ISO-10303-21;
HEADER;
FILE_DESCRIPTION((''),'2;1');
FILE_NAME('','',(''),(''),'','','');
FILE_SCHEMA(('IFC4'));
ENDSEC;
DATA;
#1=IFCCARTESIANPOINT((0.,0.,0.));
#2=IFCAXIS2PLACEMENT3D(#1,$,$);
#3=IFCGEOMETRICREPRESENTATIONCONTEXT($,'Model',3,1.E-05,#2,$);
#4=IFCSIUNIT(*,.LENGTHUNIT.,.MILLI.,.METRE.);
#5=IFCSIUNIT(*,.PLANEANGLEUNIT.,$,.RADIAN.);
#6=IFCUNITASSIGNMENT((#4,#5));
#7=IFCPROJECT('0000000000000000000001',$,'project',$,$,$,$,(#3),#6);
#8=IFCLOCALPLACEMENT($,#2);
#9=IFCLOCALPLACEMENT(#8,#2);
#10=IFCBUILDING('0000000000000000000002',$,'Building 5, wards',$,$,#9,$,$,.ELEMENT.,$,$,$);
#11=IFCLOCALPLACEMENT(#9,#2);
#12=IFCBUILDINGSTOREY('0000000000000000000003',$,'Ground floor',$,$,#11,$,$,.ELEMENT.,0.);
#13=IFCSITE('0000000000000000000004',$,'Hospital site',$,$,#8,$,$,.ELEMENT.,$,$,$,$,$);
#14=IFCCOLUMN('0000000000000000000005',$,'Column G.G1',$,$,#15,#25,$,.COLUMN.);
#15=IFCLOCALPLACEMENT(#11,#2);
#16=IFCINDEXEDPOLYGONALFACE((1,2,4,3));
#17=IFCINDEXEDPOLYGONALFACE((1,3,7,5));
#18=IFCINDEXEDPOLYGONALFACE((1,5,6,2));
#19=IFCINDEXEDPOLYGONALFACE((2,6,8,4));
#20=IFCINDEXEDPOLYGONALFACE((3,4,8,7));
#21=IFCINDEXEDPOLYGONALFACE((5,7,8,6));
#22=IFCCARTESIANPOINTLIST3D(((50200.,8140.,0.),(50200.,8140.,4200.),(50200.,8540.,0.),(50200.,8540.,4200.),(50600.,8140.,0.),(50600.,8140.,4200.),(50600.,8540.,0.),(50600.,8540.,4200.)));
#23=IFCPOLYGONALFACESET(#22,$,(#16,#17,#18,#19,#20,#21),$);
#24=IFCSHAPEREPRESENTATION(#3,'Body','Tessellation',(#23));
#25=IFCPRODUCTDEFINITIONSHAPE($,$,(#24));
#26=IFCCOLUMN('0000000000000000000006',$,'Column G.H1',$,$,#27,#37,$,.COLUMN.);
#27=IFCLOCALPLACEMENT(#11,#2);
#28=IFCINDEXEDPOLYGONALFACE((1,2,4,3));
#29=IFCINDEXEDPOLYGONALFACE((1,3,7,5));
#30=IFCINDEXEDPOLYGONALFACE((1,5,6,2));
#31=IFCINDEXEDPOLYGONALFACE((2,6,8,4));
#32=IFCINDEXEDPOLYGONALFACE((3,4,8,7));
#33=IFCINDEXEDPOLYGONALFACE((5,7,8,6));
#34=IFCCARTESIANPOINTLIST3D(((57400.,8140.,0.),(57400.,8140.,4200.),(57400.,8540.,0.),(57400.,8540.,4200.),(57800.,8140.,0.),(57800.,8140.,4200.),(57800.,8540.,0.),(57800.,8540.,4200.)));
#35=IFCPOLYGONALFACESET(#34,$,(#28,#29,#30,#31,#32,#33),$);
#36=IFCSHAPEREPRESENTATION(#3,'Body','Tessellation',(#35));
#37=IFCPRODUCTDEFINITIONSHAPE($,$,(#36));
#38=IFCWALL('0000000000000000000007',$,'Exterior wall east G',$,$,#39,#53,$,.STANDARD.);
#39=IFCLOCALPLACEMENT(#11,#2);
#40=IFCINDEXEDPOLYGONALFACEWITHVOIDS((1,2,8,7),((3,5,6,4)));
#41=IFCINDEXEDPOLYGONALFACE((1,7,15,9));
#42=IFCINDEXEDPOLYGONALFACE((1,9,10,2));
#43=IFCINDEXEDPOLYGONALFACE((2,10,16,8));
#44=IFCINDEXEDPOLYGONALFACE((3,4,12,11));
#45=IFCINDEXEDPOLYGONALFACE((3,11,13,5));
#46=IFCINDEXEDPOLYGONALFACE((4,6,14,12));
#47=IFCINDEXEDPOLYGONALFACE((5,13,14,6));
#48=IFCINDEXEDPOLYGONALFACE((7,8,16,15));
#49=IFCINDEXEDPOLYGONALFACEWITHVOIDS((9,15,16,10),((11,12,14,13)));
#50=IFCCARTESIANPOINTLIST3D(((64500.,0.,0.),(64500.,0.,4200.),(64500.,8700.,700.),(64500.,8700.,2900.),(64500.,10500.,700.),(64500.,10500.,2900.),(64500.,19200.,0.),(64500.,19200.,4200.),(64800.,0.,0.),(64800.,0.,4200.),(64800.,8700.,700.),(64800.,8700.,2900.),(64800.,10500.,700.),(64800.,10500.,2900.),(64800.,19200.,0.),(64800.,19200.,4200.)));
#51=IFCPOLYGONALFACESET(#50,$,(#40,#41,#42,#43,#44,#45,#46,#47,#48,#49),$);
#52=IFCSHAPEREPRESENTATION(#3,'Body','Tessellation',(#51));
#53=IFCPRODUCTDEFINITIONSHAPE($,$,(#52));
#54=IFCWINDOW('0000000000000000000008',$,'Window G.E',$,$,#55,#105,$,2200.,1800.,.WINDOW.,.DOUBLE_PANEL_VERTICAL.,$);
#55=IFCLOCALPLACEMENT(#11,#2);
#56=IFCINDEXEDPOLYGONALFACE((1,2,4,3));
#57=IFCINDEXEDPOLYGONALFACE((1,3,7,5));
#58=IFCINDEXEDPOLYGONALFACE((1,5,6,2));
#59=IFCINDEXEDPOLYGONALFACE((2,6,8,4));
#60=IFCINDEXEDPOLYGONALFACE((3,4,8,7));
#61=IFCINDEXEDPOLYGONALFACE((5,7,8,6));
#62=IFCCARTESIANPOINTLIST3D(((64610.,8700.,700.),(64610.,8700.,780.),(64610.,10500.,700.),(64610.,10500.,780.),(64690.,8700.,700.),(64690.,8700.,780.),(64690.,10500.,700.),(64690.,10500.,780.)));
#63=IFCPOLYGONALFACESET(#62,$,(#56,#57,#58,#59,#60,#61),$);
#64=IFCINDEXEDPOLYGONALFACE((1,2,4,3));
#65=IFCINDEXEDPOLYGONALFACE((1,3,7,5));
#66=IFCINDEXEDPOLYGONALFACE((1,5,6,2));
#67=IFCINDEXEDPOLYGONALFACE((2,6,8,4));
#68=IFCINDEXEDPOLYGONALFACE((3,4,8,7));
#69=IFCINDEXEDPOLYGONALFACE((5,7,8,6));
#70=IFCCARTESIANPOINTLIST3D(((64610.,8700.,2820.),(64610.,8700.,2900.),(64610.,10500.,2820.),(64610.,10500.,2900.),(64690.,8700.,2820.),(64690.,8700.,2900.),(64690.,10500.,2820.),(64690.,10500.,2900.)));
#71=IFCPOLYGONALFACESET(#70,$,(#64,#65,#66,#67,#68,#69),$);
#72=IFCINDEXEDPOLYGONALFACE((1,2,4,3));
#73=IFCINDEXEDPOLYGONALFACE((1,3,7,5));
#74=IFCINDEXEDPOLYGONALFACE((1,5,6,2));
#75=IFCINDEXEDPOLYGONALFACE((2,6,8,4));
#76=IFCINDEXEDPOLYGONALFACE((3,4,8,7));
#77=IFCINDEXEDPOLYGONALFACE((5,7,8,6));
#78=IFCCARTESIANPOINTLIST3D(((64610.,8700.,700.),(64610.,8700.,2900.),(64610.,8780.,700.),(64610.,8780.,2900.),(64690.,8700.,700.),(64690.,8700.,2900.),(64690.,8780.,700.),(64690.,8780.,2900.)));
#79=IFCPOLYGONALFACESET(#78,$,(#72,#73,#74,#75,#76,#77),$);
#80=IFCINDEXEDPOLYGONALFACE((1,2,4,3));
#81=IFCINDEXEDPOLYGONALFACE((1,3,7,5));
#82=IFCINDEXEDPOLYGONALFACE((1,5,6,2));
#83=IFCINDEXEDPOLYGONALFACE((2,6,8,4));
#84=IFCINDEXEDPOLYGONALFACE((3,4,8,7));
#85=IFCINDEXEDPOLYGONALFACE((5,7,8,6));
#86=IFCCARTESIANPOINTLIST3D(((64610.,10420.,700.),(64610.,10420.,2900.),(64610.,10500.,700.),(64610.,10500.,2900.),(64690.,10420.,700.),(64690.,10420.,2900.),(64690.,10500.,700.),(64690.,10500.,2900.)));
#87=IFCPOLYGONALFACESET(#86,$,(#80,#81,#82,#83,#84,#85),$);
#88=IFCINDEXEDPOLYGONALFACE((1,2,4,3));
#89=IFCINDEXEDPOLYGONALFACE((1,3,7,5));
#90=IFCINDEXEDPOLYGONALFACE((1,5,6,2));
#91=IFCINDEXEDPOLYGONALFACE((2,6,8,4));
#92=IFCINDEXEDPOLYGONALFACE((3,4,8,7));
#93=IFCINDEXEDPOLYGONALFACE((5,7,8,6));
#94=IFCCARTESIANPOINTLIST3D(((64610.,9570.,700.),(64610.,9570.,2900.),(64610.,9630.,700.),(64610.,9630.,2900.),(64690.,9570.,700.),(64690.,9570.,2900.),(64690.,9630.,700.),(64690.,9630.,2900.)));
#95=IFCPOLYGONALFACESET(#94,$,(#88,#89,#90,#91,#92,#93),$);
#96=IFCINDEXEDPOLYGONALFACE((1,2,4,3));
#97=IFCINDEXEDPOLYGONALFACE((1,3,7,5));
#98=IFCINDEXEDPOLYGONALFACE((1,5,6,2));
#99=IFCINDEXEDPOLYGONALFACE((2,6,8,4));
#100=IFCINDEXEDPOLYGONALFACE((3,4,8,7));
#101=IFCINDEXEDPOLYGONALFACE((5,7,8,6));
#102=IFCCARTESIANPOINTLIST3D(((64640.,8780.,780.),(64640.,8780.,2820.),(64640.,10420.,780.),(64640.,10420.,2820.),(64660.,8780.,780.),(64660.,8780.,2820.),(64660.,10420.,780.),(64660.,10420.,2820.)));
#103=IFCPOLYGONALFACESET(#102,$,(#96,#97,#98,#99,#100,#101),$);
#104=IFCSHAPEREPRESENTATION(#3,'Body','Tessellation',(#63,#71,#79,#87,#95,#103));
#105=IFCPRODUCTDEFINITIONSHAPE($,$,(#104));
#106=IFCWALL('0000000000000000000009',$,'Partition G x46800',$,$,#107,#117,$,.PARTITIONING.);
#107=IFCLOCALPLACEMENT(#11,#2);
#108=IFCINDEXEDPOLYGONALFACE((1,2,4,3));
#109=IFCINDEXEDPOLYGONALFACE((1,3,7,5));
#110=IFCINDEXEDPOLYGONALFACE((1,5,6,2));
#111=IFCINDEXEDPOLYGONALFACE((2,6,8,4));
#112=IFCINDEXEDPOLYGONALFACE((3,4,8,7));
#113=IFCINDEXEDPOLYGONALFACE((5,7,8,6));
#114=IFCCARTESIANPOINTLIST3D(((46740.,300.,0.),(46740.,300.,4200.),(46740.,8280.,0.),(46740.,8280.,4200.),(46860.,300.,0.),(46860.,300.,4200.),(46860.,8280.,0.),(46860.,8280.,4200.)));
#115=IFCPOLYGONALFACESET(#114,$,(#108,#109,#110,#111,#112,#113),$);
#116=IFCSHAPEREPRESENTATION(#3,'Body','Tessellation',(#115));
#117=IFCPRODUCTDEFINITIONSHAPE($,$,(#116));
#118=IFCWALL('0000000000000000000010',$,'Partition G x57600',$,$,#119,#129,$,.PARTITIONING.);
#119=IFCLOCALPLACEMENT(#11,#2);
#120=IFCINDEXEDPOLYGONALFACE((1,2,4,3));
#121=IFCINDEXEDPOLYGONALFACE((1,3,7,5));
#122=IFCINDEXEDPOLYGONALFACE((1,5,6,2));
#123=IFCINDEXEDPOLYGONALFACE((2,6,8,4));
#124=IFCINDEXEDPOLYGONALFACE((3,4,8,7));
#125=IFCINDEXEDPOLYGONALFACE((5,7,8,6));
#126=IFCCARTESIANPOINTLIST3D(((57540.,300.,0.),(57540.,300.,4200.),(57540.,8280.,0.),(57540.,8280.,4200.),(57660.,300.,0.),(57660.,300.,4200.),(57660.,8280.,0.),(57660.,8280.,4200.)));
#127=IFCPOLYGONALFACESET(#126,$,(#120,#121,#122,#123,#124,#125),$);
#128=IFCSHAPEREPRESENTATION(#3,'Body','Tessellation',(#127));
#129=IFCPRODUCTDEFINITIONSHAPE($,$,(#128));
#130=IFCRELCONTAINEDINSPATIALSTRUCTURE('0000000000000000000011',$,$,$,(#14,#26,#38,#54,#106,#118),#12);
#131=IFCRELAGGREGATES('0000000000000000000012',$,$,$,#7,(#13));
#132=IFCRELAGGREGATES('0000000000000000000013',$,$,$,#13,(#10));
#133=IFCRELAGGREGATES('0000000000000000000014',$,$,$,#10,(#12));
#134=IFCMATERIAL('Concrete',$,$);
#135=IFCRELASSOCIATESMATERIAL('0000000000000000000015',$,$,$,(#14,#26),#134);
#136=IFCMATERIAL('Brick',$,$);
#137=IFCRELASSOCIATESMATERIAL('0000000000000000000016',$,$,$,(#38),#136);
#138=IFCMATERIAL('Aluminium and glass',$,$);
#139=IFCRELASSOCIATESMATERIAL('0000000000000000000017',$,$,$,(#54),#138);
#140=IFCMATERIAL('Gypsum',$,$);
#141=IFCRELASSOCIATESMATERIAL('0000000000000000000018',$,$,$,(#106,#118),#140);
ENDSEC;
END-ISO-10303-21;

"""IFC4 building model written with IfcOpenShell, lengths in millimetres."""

from ifc_helpers import new_model, si_unit, frame, frame_2d, origin, origin_2d, place, context, project, spatial, rectangle, extrude, material, element, fill, save


model = new_model("IFC4")

# Units and contexts
model_context = context("Model", 3, precision=1e-05, world=origin())
ifc_project = project(units=[si_unit("LENGTHUNIT", "METRE", prefix="MILLI"), si_unit("PLANEANGLEUNIT", "RADIAN")], contexts=[model_context])

# Site, building, storey
site_placement = place(None, origin())
site = spatial("IfcSite", under=ifc_project, at=site_placement, Name="Hospital site", CompositionType="ELEMENT")
building_placement = place(site_placement, origin())
building = spatial("IfcBuilding", under=site, at=building_placement, Name="Building 5, wards", CompositionType="ELEMENT")
storey_placement = place(building_placement, origin())
storey = spatial("IfcBuildingStorey", under=building, at=storey_placement, Name="Ground floor", CompositionType="ELEMENT", Elevation=0.0)

# Columns
ifc_material_1 = material(Name="Concrete")
for number, where, name in (
    (1, (50400.0, 8340.0, 0.0), "Column G.G1"),
    (2, (57600.0, 8340.0, 0.0), "Column G.H1"),
):
    element("IfcColumn", number, at=place(storey_placement, frame(where)), inside=storey, material=ifc_material_1, Name=name, PredefinedType="COLUMN", context=model_context, shape_type="SweptSolid", body=[
        extrude(rectangle(XDim=400.0, YDim=400.0, at=origin_2d()), origin(), (0.0, 0.0, 1.0), 4200.0),
    ])

# Wall, opening, window
ifc_material_2 = material(Name="Brick")
wall_placement = place(storey_placement, frame((64800.0, 0.0, 0.0), x_axis=(0.0, 1.0, 0.0)))
wall = element("IfcWall", 3, at=wall_placement, inside=storey, material=ifc_material_2, Name="Exterior wall east G", PredefinedType="STANDARD", context=model_context, shape_type="SweptSolid", body=[
    extrude(rectangle(XDim=19200.0, YDim=300.0, at=frame_2d((9600.0, 150.0))), origin(), (0.0, 0.0, 1.0), 4200.0),
])
opening_placement = place(wall_placement, frame((8700.0, -50.0, 700.0)))
opening = element("IfcOpeningElement", 4, at=opening_placement, cuts=wall, PredefinedType="OPENING", context=model_context, shape_type="SweptSolid", body=[
    extrude(rectangle(XDim=1800.0, YDim=400.0, at=frame_2d((900.0, 200.0))), origin(), (0.0, 0.0, 1.0), 2200.0),
])
ifc_material_3 = material(Name="Aluminium and glass")
window_placement = place(opening_placement, frame((0.0, 160.0, 0.0)))
window = element("IfcWindow", 5, at=window_placement, inside=storey, material=ifc_material_3, Name="Window G.E", OverallHeight=2200.0, OverallWidth=1800.0, PartitioningType="DOUBLE_PANEL_VERTICAL", PredefinedType="WINDOW", context=model_context, shape_type="SweptSolid", body=[
    extrude(rectangle(XDim=1800.0, YDim=80.0, at=frame_2d((900.0, 40.0))), origin(), (0.0, 0.0, 1.0), 80.0),
    extrude(rectangle(XDim=1800.0, YDim=80.0, at=frame_2d((900.0, 40.0))), frame((0.0, 0.0, 2120.0)), (0.0, 0.0, 1.0), 80.0),
    extrude(rectangle(XDim=80.0, YDim=80.0, at=frame_2d((40.0, 40.0))), origin(), (0.0, 0.0, 1.0), 2200.0),
    extrude(rectangle(XDim=80.0, YDim=80.0, at=frame_2d((1760.0, 40.0))), origin(), (0.0, 0.0, 1.0), 2200.0),
    extrude(rectangle(XDim=60.0, YDim=80.0, at=frame_2d((900.0, 40.0))), origin(), (0.0, 0.0, 1.0), 2200.0),
    extrude(rectangle(XDim=1640.0, YDim=20.0, at=frame_2d((900.0, 40.0))), frame((0.0, 0.0, 80.0)), (0.0, 0.0, 1.0), 2040.0),
])
fill(opening, window)

# Walls
ifc_material_4 = material(Name="Gypsum")
for number, where, x_axis, name in (
    (6, (46860.0, 300.0, 0.0), (0.0, 1.0, 0.0), "Partition G x46800"),
    (7, (57660.0, 300.0, 0.0), (0.0, 1.0, 0.0), "Partition G x57600"),
):
    element("IfcWall", number, at=place(storey_placement, frame(where, x_axis=x_axis)), inside=storey, material=ifc_material_4, Name=name, PredefinedType="PARTITIONING", context=model_context, shape_type="SweptSolid", body=[
        extrude(rectangle(XDim=7980.0, YDim=120.0, at=frame_2d((3990.0, 60.0))), origin(), (0.0, 0.0, 1.0), 4200.0),
    ])

save(model, "model.ifc")
